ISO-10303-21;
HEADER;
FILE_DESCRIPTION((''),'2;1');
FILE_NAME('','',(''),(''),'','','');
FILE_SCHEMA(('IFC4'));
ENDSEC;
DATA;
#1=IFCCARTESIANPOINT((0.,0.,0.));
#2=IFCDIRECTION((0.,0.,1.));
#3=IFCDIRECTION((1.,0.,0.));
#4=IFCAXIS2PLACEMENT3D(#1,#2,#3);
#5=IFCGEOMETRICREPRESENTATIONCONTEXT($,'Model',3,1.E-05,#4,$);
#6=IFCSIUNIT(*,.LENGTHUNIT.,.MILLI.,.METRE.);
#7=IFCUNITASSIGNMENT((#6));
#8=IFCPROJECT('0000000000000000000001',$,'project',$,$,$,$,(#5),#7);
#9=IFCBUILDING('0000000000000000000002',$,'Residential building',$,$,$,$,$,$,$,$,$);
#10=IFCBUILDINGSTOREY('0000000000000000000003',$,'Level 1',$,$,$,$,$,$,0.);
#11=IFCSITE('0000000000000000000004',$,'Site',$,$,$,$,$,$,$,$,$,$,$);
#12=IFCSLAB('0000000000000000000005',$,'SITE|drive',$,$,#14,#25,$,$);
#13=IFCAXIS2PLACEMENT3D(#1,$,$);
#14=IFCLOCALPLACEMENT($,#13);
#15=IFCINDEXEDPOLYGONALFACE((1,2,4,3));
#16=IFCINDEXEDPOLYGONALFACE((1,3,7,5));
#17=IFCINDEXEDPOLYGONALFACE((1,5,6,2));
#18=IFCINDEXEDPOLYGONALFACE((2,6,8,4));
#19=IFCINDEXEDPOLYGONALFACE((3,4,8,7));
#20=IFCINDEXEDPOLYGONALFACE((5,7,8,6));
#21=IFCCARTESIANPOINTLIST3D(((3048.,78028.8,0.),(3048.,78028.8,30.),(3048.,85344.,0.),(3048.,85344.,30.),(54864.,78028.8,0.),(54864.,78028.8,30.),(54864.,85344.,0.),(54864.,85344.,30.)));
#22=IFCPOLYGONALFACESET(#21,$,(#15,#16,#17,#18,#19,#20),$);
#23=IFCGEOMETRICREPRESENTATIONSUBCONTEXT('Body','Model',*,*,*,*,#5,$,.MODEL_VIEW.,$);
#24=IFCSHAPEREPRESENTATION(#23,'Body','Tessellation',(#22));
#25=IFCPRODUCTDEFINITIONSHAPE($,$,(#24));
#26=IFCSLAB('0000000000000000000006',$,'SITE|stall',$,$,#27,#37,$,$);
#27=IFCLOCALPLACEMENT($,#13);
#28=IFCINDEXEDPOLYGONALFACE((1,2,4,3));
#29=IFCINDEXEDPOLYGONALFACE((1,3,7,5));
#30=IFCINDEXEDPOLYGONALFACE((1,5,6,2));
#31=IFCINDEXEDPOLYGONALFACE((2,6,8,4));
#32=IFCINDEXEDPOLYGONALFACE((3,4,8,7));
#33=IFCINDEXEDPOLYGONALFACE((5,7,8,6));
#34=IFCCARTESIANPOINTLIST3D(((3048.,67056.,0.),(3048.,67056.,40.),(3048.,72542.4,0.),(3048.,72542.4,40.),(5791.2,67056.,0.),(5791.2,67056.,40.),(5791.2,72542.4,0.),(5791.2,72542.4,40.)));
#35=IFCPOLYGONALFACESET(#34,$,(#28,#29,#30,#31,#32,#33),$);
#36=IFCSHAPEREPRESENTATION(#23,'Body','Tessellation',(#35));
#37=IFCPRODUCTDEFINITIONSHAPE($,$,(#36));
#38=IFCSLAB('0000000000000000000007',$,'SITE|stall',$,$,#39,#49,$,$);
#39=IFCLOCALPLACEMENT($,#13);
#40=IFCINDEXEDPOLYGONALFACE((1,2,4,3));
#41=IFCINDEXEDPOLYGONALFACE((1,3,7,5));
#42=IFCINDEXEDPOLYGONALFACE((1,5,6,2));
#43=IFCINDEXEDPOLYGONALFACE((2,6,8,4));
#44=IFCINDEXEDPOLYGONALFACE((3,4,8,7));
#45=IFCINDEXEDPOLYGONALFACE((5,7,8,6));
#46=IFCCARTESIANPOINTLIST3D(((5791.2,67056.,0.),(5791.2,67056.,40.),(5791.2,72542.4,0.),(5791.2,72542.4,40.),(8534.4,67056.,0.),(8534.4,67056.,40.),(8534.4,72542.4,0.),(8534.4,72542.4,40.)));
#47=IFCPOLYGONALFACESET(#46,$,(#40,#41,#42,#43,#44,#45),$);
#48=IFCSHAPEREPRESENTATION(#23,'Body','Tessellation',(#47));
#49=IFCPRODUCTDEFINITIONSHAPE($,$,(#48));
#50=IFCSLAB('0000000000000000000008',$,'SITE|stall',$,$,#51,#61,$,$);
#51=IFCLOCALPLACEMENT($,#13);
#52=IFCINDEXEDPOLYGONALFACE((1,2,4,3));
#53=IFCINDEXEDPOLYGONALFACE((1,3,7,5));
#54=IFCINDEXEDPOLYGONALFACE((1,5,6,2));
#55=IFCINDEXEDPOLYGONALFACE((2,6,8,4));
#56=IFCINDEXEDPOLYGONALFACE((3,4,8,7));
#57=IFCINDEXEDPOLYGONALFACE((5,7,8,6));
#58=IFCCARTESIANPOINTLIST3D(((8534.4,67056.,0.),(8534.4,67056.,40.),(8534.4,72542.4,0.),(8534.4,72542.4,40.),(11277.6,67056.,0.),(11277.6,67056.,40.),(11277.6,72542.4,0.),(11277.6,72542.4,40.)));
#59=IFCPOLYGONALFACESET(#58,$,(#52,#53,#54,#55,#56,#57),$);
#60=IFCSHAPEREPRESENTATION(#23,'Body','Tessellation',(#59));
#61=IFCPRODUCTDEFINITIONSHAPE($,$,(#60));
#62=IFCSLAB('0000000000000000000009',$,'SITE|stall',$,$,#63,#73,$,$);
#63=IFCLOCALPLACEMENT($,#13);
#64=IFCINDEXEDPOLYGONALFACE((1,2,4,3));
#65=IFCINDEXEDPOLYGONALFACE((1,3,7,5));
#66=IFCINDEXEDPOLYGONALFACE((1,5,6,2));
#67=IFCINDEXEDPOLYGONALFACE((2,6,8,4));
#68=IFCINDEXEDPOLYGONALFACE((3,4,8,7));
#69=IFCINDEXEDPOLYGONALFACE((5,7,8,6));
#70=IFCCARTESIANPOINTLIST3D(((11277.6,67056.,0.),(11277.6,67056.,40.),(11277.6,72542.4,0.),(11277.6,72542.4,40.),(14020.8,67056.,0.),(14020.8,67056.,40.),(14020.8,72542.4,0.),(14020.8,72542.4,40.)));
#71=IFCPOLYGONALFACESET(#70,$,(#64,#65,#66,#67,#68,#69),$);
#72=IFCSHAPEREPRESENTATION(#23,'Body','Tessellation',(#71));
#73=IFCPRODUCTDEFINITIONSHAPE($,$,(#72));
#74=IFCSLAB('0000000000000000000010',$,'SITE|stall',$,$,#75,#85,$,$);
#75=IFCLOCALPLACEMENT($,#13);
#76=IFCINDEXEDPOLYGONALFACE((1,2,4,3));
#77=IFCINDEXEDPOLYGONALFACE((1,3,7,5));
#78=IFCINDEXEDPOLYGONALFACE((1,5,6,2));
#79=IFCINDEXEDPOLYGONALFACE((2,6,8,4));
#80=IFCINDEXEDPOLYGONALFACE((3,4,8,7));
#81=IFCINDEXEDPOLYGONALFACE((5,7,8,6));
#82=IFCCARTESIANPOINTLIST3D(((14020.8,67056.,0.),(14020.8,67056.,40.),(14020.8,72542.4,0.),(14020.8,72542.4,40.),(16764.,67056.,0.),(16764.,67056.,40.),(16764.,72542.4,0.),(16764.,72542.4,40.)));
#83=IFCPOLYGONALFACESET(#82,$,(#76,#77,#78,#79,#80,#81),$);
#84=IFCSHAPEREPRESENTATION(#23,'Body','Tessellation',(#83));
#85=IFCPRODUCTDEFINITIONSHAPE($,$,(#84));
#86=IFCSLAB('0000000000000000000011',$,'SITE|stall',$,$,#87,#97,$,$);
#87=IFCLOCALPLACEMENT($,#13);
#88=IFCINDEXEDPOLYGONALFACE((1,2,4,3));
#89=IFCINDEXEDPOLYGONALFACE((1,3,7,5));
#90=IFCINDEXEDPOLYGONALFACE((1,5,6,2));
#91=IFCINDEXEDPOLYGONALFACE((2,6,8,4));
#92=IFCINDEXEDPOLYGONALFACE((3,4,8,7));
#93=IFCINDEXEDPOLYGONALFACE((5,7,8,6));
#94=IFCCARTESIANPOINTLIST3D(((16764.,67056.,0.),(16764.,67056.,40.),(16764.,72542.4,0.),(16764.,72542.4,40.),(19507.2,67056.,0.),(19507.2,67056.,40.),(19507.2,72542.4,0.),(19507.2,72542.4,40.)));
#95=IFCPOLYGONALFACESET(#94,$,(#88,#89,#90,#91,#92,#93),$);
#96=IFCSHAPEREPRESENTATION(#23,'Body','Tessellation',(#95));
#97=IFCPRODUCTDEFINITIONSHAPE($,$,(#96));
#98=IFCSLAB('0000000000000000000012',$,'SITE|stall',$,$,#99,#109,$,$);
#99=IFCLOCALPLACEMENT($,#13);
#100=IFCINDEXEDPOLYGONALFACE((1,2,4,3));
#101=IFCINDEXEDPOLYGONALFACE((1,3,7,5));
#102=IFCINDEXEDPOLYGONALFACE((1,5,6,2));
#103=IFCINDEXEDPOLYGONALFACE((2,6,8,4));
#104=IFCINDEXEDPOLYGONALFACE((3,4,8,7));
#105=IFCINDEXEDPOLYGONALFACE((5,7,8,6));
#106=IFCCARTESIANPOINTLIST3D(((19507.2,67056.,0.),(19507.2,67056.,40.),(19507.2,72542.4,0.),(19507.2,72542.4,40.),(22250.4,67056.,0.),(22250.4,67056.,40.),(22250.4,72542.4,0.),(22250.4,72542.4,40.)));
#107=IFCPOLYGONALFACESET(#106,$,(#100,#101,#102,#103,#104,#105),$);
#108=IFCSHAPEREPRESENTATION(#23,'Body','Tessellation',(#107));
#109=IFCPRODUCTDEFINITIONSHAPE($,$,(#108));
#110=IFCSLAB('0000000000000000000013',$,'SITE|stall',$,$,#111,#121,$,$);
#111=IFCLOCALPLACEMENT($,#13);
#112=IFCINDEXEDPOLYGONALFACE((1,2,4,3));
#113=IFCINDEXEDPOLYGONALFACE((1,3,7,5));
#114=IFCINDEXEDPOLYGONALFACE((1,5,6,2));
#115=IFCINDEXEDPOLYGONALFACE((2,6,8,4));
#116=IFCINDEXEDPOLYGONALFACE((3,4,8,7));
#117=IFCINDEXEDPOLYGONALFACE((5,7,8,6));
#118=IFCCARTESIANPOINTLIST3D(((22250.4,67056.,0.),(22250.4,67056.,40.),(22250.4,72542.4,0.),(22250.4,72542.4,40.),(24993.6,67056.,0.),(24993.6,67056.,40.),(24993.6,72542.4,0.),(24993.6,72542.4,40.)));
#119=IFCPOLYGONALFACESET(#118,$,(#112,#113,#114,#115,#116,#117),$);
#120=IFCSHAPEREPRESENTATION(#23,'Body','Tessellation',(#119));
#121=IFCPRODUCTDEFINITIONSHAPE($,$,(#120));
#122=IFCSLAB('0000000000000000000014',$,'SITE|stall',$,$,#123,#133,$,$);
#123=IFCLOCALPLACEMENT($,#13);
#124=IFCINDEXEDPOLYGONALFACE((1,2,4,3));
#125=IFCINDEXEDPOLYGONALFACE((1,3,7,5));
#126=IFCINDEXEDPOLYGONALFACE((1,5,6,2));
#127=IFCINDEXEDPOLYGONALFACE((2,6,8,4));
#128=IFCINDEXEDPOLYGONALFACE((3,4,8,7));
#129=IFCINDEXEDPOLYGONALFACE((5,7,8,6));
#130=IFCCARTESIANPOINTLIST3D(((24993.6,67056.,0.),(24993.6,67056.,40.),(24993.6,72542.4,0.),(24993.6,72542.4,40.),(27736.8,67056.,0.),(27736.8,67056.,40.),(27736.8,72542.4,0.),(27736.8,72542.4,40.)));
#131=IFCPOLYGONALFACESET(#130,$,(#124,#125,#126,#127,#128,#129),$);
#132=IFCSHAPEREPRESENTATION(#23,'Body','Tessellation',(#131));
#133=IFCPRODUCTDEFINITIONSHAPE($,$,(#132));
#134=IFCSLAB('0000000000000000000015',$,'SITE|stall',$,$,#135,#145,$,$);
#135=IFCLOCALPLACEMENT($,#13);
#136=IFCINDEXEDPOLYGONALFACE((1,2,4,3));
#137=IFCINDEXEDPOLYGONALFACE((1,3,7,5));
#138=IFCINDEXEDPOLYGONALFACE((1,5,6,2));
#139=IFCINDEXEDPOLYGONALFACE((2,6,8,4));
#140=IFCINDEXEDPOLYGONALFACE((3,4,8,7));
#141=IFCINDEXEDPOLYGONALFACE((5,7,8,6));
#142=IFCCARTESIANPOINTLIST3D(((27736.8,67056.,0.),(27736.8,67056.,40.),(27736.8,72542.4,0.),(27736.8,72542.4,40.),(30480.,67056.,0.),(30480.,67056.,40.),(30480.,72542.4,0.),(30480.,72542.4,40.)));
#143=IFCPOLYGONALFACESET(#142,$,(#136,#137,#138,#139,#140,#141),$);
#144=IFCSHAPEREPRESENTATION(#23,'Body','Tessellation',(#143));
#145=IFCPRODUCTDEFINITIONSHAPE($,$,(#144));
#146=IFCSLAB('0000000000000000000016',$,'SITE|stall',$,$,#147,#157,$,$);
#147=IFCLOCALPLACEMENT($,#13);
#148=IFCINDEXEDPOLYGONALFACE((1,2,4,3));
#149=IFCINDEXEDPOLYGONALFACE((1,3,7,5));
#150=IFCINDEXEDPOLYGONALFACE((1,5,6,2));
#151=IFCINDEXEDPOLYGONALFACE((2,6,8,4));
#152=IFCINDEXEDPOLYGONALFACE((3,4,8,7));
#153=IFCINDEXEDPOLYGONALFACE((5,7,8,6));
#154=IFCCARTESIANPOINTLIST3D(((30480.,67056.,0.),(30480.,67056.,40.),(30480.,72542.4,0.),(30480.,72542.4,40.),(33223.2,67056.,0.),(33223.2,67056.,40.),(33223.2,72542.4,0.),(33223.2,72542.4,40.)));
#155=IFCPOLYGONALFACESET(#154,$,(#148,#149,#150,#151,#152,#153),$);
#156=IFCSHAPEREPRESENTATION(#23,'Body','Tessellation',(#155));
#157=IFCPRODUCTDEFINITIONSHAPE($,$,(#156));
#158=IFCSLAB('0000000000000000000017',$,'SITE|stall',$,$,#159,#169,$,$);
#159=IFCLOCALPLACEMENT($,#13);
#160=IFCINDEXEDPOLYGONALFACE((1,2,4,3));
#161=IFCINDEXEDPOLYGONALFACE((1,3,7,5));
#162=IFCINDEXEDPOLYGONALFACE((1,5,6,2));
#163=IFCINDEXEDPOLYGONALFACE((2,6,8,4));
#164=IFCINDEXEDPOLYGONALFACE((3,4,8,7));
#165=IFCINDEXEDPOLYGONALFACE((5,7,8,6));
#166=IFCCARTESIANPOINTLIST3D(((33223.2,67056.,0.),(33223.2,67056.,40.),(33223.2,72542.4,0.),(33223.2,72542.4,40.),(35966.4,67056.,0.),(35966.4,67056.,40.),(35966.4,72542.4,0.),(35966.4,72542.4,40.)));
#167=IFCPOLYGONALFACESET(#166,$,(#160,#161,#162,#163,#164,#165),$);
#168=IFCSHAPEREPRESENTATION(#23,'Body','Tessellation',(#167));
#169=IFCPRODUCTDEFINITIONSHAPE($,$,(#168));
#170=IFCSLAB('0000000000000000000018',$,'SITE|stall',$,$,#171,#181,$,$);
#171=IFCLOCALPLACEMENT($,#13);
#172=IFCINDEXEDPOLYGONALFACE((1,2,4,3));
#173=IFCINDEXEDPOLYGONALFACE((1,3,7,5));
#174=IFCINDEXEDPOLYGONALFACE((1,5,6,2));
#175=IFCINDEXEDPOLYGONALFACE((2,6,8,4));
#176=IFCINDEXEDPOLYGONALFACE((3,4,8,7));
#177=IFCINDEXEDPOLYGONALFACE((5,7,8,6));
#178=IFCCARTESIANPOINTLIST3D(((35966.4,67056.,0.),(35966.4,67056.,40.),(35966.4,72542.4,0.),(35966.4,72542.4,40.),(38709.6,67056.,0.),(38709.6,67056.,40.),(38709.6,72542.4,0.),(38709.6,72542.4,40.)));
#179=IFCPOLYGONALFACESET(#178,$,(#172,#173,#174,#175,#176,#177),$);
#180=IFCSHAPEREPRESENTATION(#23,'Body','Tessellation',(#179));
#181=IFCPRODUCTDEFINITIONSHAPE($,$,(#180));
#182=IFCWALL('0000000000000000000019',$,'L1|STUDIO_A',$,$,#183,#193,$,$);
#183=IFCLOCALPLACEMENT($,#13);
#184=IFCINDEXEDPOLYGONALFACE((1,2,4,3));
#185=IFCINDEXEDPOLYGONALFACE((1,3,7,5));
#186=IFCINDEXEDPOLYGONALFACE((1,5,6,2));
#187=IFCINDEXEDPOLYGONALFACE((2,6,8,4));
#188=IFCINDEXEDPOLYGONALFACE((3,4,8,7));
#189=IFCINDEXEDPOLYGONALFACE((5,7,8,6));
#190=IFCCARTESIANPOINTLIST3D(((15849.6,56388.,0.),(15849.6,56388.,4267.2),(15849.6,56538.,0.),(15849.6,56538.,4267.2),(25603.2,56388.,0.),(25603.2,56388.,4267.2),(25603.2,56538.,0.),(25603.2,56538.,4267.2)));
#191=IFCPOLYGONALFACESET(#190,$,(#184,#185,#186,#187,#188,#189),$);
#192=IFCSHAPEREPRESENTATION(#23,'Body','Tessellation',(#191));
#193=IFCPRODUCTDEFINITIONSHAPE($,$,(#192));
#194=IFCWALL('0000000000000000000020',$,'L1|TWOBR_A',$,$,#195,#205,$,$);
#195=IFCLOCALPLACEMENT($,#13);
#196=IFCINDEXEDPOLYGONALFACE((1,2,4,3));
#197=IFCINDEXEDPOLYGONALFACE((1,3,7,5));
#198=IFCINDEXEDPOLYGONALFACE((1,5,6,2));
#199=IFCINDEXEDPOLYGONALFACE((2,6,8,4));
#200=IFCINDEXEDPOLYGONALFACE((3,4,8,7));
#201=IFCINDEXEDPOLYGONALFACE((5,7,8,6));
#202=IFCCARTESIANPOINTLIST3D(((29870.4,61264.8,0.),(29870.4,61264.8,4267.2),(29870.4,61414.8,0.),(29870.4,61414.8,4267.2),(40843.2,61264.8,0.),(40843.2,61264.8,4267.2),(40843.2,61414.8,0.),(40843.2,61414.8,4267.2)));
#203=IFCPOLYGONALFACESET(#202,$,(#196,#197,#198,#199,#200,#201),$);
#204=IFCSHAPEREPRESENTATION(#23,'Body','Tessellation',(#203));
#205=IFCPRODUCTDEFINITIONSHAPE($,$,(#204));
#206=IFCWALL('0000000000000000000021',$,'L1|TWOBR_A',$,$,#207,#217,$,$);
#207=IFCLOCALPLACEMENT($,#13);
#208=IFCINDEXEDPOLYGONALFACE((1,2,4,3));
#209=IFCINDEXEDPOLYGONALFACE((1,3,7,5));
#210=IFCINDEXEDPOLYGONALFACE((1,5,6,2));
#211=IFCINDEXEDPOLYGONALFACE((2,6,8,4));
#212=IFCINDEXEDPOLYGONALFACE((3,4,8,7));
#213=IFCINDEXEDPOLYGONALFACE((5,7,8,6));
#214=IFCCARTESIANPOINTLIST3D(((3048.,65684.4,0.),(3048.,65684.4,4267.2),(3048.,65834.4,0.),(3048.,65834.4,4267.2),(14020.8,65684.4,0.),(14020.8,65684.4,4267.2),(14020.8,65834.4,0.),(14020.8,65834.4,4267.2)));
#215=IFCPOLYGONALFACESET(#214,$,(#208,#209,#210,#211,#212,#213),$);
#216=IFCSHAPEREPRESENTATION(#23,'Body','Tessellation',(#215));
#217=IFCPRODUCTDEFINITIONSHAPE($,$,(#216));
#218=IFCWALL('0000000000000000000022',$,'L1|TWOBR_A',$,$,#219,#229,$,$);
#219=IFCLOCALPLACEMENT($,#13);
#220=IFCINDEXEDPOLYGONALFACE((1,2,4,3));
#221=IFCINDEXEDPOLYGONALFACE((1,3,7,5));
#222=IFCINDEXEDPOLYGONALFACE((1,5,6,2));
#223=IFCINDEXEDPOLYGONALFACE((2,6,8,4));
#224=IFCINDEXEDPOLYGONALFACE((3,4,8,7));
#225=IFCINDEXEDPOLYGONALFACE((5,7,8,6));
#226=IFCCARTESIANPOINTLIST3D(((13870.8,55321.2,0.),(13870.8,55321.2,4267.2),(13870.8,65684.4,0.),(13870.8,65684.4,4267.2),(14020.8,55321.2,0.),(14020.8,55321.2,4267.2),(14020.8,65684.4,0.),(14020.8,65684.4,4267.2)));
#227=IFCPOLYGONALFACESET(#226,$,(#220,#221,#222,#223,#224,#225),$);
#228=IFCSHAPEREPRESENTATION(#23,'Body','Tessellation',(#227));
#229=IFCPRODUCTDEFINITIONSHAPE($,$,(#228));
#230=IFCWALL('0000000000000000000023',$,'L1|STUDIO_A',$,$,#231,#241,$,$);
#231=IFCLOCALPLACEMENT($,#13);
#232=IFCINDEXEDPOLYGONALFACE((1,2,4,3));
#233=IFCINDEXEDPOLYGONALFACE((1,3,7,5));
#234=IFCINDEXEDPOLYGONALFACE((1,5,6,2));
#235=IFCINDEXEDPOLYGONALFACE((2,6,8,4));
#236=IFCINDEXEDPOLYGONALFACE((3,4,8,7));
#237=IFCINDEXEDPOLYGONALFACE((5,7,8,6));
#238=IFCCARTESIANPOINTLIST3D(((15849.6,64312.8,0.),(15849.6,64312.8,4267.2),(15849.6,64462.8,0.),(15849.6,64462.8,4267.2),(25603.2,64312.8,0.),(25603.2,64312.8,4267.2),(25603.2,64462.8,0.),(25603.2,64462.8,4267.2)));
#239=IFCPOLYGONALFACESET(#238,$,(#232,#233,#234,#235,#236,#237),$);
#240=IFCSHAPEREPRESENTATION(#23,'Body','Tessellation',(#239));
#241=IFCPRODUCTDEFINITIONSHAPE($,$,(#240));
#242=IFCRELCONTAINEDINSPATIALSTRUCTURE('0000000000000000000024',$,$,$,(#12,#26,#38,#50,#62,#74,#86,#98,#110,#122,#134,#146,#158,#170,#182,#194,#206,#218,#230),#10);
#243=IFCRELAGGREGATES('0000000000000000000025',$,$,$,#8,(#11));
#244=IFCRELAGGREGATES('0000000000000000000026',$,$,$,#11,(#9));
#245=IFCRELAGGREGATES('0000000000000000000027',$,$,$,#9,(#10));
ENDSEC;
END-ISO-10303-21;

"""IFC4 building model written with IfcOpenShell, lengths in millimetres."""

from ifc_helpers import new_model, si_unit, frame, origin_with_axes, place, context, subcontext, project, spatial, indexed_curve, outline, extrude, element, save


model = new_model("IFC4")

# Units and contexts
model_context = context("Model", 3, precision=1e-05, world=origin_with_axes())
body_context = subcontext(model_context, "Body", "Model", "MODEL_VIEW")
ifc_project = project(units=[si_unit("LENGTHUNIT", "METRE", prefix="MILLI")], contexts=[model_context])

# Site, building, storey
site = spatial("IfcSite", under=ifc_project, Name="Site")
building = spatial("IfcBuilding", under=site, Name="Residential building")
storey = spatial("IfcBuildingStorey", under=building, Name="Level 1", Elevation=0.0)

# Slabs
slab_placement = place(None, frame((3048.0, 78028.8, 0.0), z_axis=(0.0, 0.0, 1.0), x_axis=(1.0, 0.0, 0.0)))
element("IfcSlab", 1, at=slab_placement, inside=storey, Name="SITE|drive", context=body_context, shape_type="SweptSolid", body=[
    extrude(outline(indexed_curve([(0.0, 0.0), (51816.0, 0.0), (51816.0, 7315.2), (0.0, 7315.2), (0.0, 0.0)])), None, (0.0, 0.0, 1.0), 30.0),
])
for number, where, z_axis, x_axis, name in (
    (2, (3048.0, 67056.0, 0.0), (0.0, 0.0, 1.0), (1.0, 0.0, 0.0), "SITE|stall"),
    (3, (5791.2, 67056.0, 0.0), (0.0, 0.0, 1.0), (1.0, 0.0, 0.0), "SITE|stall"),
    (4, (8534.4, 67056.0, 0.0), (0.0, 0.0, 1.0), (1.0, 0.0, 0.0), "SITE|stall"),
    (5, (11277.6, 67056.0, 0.0), (0.0, 0.0, 1.0), (1.0, 0.0, 0.0), "SITE|stall"),
    (6, (14020.8, 67056.0, 0.0), (0.0, 0.0, 1.0), (1.0, 0.0, 0.0), "SITE|stall"),
    (7, (16764.0, 67056.0, 0.0), (0.0, 0.0, 1.0), (1.0, 0.0, 0.0), "SITE|stall"),
    (8, (19507.2, 67056.0, 0.0), (0.0, 0.0, 1.0), (1.0, 0.0, 0.0), "SITE|stall"),
    (9, (22250.4, 67056.0, 0.0), (0.0, 0.0, 1.0), (1.0, 0.0, 0.0), "SITE|stall"),
    (10, (24993.6, 67056.0, 0.0), (0.0, 0.0, 1.0), (1.0, 0.0, 0.0), "SITE|stall"),
    (11, (27736.8, 67056.0, 0.0), (0.0, 0.0, 1.0), (1.0, 0.0, 0.0), "SITE|stall"),
    (12, (30480.0, 67056.0, 0.0), (0.0, 0.0, 1.0), (1.0, 0.0, 0.0), "SITE|stall"),
    (13, (33223.2, 67056.0, 0.0), (0.0, 0.0, 1.0), (1.0, 0.0, 0.0), "SITE|stall"),
    (14, (35966.4, 67056.0, 0.0), (0.0, 0.0, 1.0), (1.0, 0.0, 0.0), "SITE|stall"),
):
    element("IfcSlab", number, at=place(None, frame(where, z_axis=z_axis, x_axis=x_axis)), inside=storey, Name=name, context=body_context, shape_type="SweptSolid", body=[
        extrude(outline(indexed_curve([(0.0, 0.0), (2743.2, 0.0), (2743.2, 5486.4), (0.0, 5486.4), (0.0, 0.0)])), None, (0.0, 0.0, 1.0), 40.0),
    ])

# Walls
wall_1_placement = place(None, frame((15849.6, 56388.0, 0.0), z_axis=(0.0, 0.0, 1.0), x_axis=(1.0, 0.0, 0.0)))
element("IfcWall", 15, at=wall_1_placement, inside=storey, Name="L1|STUDIO_A", context=body_context, shape_type="SweptSolid", body=[
    extrude(outline(indexed_curve([(0.0, 0.0), (0.0, 150.0), (9753.6, 150.0), (9753.6, 0.0), (0.0, 0.0)], self_intersect=False)), origin_with_axes(), (0.0, 0.0, 1.0), 4267.2),
])
for number, where, z_axis, x_axis, name in (
    (16, (29870.4, 61264.8, 0.0), (0.0, 0.0, 1.0), (1.0, 0.0, 0.0), "L1|TWOBR_A"),
    (17, (3048.0, 65684.4, 0.0), (0.0, 0.0, 1.0), (1.0, 0.0, 0.0), "L1|TWOBR_A"),
):
    element("IfcWall", number, at=place(None, frame(where, z_axis=z_axis, x_axis=x_axis)), inside=storey, Name=name, context=body_context, shape_type="SweptSolid", body=[
        extrude(outline(indexed_curve([(0.0, 0.0), (0.0, 150.0), (10972.8, 150.0), (10972.8, 0.0), (0.0, 0.0)], self_intersect=False)), origin_with_axes(), (0.0, 0.0, 1.0), 4267.2),
    ])
wall_2_placement = place(None, frame((14020.8, 55321.2, 0.0), z_axis=(0.0, 0.0, 1.0), x_axis=(0.0, 1.0, 0.0)))
element("IfcWall", 18, at=wall_2_placement, inside=storey, Name="L1|TWOBR_A", context=body_context, shape_type="SweptSolid", body=[
    extrude(outline(indexed_curve([(0.0, 0.0), (0.0, 150.0), (10363.2, 150.0), (10363.2, 0.0), (0.0, 0.0)], self_intersect=False)), origin_with_axes(), (0.0, 0.0, 1.0), 4267.2),
])
for number, where, z_axis, x_axis, name in (
    (19, (15849.6, 64312.8, 0.0), (0.0, 0.0, 1.0), (1.0, 0.0, 0.0), "L1|STUDIO_A"),
):
    element("IfcWall", number, at=place(None, frame(where, z_axis=z_axis, x_axis=x_axis)), inside=storey, Name=name, context=body_context, shape_type="SweptSolid", body=[
        extrude(outline(indexed_curve([(0.0, 0.0), (0.0, 150.0), (9753.6, 150.0), (9753.6, 0.0), (0.0, 0.0)], self_intersect=False)), origin_with_axes(), (0.0, 0.0, 1.0), 4267.2),
    ])

save(model, "model.ifc")
